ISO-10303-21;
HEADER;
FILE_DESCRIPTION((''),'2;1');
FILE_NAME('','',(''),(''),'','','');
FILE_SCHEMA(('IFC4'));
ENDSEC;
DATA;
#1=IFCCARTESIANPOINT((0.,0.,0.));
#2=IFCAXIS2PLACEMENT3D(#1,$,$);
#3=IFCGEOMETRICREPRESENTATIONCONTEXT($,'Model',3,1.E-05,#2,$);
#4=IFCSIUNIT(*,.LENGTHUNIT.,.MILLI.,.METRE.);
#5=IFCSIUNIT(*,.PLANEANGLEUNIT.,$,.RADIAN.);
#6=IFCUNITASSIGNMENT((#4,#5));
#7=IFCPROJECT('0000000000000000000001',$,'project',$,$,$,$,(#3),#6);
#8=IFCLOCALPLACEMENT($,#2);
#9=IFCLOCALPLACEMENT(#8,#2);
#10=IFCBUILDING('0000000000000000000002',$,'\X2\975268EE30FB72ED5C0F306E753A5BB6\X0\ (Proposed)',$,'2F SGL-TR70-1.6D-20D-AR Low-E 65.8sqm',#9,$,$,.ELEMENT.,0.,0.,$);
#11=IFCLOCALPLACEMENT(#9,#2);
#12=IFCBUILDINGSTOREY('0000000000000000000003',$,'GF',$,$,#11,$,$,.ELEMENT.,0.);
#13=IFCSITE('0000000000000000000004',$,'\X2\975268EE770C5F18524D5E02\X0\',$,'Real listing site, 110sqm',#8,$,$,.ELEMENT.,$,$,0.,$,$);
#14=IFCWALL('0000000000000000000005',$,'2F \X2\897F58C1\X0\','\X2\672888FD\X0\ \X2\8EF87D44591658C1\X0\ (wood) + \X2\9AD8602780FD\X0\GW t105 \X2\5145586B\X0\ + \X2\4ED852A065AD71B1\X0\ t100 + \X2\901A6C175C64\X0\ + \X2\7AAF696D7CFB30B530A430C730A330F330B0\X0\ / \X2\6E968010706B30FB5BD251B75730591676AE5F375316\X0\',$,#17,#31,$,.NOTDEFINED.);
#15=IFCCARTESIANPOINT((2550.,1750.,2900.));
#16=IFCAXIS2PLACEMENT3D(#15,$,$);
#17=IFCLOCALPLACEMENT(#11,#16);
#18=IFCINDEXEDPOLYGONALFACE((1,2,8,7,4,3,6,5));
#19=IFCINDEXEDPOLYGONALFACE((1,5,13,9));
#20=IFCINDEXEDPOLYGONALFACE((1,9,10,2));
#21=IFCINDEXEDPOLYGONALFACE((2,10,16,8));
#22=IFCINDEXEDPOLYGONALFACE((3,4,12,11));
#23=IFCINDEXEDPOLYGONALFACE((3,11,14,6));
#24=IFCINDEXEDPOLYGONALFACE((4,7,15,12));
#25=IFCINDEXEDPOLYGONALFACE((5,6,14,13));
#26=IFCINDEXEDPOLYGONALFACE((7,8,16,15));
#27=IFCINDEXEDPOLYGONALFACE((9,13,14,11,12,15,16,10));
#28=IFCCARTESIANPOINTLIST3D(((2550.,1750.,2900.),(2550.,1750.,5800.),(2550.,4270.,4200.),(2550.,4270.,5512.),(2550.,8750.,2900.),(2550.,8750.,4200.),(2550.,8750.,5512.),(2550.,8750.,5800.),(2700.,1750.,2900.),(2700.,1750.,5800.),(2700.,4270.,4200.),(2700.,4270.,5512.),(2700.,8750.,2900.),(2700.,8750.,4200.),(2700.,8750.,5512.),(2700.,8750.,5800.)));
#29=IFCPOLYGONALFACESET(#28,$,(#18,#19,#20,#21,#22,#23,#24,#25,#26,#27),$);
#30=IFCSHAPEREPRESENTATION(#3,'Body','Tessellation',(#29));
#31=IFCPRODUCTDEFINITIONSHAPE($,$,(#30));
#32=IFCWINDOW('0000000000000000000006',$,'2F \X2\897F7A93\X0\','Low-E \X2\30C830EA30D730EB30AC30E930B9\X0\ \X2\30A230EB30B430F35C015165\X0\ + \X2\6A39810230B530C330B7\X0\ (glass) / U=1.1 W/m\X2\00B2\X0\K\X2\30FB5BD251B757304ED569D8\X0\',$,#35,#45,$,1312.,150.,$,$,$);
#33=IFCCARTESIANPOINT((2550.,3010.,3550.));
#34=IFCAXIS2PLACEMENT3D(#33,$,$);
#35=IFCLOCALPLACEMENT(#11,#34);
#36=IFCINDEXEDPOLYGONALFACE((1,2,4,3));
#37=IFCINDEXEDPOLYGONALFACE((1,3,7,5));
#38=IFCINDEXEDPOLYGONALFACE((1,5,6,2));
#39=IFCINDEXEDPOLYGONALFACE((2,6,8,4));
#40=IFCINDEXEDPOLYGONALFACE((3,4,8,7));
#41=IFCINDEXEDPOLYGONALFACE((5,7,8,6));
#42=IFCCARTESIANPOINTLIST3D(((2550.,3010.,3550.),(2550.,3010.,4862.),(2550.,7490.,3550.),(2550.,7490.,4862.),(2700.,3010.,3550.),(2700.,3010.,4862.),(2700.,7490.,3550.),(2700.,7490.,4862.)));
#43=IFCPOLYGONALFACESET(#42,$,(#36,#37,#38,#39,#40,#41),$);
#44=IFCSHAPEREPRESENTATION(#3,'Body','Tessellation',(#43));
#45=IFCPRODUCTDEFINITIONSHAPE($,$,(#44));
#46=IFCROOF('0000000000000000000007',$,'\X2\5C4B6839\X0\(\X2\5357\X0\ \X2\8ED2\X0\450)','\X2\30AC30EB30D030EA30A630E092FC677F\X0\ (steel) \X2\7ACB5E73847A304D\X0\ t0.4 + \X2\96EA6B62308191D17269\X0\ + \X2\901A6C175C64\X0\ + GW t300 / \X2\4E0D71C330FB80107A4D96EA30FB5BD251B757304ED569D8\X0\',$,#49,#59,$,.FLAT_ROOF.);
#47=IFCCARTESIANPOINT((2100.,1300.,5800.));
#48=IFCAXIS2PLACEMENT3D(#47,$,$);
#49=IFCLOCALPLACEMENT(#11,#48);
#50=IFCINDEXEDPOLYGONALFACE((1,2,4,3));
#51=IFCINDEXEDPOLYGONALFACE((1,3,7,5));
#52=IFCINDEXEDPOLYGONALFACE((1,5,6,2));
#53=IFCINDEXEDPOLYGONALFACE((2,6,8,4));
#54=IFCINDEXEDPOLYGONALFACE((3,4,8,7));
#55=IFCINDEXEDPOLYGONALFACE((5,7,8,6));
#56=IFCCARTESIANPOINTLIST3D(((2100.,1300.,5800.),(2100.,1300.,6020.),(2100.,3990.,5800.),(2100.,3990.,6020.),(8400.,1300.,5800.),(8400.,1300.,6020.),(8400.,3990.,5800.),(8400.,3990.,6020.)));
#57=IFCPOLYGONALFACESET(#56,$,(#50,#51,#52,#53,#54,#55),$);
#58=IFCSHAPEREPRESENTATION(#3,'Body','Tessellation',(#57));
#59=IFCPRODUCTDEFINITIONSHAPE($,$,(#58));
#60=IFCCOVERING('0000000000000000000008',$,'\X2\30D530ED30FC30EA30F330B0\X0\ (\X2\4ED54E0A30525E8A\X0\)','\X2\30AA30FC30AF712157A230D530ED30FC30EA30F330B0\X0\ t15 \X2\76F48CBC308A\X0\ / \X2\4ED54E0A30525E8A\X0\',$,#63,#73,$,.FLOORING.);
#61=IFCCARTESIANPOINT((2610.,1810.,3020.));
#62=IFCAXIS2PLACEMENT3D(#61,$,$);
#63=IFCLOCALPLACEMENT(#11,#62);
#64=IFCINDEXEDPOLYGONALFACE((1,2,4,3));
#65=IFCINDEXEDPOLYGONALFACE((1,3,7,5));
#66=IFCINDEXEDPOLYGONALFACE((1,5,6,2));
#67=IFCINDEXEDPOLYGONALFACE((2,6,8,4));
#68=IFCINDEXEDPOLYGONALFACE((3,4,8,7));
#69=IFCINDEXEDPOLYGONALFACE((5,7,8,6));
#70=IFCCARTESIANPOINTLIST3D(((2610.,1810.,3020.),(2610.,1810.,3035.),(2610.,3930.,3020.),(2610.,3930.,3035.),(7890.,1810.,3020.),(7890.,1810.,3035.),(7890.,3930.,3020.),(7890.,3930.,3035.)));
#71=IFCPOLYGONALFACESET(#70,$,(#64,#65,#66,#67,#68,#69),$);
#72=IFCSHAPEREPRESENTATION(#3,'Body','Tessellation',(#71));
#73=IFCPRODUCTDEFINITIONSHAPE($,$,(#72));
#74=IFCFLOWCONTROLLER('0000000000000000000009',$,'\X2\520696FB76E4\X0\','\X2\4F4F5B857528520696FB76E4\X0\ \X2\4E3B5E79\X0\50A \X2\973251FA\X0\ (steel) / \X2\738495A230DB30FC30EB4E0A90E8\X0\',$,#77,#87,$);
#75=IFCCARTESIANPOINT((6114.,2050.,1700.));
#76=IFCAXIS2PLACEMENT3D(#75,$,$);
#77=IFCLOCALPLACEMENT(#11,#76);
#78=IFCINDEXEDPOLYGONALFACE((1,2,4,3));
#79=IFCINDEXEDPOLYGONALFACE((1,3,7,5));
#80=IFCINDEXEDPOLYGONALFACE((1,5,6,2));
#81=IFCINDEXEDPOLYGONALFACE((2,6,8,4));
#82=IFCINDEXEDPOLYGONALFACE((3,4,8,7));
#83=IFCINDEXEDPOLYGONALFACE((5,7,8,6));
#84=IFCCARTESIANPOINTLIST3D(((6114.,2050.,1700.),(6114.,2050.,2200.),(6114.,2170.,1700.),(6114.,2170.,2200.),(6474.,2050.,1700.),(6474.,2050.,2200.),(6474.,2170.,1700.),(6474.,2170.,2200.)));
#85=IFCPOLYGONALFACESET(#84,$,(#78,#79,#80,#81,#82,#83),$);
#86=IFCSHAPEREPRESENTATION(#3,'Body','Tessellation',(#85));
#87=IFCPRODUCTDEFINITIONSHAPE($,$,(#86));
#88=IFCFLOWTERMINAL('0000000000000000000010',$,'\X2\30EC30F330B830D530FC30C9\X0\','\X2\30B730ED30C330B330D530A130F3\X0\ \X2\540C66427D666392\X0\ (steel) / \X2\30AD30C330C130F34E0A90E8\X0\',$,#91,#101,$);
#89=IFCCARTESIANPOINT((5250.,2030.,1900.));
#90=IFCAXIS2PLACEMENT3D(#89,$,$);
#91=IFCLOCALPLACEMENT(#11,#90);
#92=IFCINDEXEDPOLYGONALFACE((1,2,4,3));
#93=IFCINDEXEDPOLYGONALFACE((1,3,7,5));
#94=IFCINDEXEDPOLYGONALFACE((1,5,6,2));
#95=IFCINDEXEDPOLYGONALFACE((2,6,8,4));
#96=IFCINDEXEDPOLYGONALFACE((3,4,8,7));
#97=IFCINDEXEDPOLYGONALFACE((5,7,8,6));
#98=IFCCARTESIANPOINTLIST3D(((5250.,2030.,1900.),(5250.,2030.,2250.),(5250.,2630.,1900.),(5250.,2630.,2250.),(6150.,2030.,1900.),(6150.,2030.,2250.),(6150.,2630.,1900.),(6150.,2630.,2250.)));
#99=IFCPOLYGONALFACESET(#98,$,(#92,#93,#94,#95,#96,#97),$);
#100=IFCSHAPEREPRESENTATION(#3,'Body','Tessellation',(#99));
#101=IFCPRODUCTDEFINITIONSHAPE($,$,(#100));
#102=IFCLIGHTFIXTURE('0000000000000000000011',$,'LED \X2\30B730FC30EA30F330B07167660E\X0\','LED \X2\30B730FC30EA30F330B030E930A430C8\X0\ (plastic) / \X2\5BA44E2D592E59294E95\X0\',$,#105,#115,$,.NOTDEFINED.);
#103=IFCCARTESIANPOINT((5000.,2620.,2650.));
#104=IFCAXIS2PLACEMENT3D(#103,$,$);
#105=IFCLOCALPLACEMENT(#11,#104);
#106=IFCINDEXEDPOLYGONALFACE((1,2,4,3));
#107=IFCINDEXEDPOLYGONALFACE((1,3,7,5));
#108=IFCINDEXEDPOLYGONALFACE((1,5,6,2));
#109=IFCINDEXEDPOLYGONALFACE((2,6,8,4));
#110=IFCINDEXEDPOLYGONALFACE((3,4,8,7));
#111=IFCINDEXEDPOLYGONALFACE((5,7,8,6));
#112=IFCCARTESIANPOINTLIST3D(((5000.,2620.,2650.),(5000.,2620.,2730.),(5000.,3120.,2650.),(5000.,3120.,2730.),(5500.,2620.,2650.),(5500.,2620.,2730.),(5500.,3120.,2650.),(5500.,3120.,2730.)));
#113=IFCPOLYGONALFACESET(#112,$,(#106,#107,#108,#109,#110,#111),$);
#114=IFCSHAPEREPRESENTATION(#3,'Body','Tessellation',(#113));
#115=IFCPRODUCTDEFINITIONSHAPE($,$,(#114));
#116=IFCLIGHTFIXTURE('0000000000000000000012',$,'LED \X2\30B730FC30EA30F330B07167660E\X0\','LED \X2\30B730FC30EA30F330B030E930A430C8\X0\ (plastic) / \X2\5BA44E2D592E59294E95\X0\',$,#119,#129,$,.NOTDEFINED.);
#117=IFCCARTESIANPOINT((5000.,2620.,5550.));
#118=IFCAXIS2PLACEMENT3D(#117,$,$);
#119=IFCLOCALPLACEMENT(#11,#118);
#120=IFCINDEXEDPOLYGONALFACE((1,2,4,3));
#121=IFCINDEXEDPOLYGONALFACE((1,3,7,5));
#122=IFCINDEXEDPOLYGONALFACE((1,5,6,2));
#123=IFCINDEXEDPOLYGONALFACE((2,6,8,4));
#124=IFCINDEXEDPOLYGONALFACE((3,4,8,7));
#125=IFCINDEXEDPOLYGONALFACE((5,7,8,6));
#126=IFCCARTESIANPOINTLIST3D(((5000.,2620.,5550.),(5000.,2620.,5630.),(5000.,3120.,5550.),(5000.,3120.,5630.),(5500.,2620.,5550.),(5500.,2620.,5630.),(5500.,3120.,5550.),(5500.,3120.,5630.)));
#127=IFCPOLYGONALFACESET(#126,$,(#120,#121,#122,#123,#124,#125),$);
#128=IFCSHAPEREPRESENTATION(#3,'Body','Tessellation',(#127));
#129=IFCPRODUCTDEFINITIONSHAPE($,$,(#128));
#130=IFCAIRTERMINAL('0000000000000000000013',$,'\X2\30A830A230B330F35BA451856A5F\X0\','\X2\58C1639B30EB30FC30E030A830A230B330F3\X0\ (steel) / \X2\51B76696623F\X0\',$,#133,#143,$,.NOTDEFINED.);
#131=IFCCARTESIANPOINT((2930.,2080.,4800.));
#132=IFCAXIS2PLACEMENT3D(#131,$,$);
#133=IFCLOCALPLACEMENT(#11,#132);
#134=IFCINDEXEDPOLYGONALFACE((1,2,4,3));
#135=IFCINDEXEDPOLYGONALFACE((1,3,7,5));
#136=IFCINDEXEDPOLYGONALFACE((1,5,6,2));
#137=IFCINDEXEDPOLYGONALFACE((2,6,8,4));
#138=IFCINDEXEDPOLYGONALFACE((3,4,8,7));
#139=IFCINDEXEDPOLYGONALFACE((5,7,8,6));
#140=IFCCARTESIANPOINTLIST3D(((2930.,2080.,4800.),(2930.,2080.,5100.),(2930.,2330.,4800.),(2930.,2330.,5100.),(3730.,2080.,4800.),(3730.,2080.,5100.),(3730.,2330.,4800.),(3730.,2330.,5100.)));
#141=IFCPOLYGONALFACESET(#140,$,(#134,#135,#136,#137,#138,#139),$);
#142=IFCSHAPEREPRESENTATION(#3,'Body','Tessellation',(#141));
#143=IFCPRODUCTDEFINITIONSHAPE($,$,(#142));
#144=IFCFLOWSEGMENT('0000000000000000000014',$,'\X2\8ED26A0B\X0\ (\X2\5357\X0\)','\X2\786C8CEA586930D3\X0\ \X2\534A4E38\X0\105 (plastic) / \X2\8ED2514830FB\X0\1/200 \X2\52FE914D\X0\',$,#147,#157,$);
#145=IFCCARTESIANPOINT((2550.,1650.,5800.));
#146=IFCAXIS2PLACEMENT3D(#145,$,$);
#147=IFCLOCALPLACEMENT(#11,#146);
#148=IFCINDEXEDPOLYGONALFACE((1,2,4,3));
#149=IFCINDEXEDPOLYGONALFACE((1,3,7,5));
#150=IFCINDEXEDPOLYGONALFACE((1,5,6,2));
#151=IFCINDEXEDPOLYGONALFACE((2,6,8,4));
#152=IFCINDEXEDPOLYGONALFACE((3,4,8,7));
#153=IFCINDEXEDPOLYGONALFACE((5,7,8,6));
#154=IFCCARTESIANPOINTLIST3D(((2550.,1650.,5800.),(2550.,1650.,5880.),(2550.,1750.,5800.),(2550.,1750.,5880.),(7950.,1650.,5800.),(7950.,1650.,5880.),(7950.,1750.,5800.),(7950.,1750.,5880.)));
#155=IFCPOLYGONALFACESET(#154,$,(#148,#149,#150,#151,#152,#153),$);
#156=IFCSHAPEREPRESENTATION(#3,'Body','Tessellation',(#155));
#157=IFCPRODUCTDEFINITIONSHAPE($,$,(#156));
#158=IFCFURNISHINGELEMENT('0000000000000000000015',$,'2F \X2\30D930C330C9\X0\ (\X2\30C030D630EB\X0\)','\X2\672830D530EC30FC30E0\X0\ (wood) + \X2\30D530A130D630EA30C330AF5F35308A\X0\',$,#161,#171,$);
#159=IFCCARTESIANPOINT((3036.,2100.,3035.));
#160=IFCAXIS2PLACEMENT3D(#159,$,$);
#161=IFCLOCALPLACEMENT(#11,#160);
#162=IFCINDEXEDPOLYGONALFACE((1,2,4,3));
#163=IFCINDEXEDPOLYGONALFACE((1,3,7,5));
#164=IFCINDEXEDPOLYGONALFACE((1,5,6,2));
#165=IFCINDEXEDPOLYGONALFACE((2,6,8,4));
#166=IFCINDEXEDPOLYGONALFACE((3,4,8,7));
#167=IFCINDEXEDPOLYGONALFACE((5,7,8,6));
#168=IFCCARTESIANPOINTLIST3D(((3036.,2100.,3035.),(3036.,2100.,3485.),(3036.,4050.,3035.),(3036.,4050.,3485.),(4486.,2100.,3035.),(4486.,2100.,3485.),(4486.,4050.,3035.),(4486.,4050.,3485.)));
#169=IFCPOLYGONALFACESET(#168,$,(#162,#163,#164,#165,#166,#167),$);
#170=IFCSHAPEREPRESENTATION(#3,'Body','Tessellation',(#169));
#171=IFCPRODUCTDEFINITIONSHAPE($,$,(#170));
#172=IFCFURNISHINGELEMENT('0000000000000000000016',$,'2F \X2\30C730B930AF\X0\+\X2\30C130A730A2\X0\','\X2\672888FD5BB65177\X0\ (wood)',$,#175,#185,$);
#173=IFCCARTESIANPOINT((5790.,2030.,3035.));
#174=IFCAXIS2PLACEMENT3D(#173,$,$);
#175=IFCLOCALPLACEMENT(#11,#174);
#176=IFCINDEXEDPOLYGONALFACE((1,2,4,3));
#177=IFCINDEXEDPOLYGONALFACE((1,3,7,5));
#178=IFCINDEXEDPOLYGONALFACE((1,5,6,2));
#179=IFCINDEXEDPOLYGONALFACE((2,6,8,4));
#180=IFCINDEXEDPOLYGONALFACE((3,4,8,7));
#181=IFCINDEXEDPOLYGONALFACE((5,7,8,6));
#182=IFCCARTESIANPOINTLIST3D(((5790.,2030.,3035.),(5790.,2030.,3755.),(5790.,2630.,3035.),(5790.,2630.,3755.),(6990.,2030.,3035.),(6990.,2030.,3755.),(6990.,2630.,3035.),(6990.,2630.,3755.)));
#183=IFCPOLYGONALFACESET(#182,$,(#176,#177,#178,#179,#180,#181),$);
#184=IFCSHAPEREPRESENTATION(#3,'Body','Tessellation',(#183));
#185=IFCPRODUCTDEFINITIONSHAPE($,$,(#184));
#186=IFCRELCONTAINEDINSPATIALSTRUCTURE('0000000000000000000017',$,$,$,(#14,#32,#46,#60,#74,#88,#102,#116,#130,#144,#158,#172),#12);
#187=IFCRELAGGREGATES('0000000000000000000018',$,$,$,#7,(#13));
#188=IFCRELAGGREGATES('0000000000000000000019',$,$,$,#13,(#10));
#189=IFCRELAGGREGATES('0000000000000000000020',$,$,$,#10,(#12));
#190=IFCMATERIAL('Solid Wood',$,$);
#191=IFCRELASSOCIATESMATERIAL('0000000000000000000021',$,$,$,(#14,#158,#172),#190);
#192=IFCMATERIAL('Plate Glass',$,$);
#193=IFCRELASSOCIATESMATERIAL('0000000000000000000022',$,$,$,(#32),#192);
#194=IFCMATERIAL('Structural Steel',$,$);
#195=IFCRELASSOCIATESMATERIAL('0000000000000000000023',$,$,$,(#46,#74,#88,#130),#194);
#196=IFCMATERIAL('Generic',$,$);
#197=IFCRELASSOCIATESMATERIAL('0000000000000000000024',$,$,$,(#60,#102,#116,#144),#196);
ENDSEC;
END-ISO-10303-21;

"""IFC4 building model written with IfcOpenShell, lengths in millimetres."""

from ifc_helpers import new_model, si_unit, frame, frame_2d, origin, place, context, project, spatial, rectangle, extrude, material, element, fill, save


model = new_model("IFC4")

# Units and contexts
model_context = context("Model", 3, precision=1e-05, world=origin())
ifc_project = project(units=[si_unit("LENGTHUNIT", "METRE", prefix="MILLI"), si_unit("PLANEANGLEUNIT", "RADIAN")], contexts=[model_context])

# Site, building, storey
site_placement = place(None, origin())
site = spatial("IfcSite", under=ifc_project, at=site_placement, Name="青森県弘前市", ObjectType="Real listing site, 110sqm", CompositionType="ELEMENT", RefElevation=0.0)
building_placement = place(site_placement, origin())
building = spatial("IfcBuilding", under=site, at=building_placement, Name="青森・狭小の町家 (Proposed)", ObjectType="2F SGL-TR70-1.6D-20D-AR Low-E 65.8sqm", CompositionType="ELEMENT", ElevationOfRefHeight=0.0, ElevationOfTerrain=0.0)
storey_placement = place(building_placement, origin())
storey = spatial("IfcBuildingStorey", under=building, at=storey_placement, Name="GF", CompositionType="ELEMENT", Elevation=0.0)

# Shared definitions
ifc_material_1 = material(Name="Solid Wood")

# Wall, opening, window
ifc_material_2 = material(Name="Plate Glass")
wall_1_placement = place(storey_placement, frame((2550.0, 1750.0, 2900.0)))
wall_1 = element("IfcWall", 1, at=wall_1_placement, inside=storey, material=ifc_material_1, Name="2F 西壁", Description="木製 軸組外壁 (wood) + 高性能GW t105 充填 + 付加断熱 t100 + 通気層 + 窯業系サイディング / 準耐火・寒冷地外皮強化", PredefinedType="NOTDEFINED", context=model_context, shape_type="SweptSolid", body=[
    extrude(rectangle(XDim=150.0, YDim=7000.0, at=frame_2d((75.0, 3500.0))), frame((2550.0, 1750.0, 2900.0)), (0.0, 0.0, 1.0), 2900.0),
])
opening_1_placement = place(storey_placement, frame((2550.0, 3010.0, 3550.0)))
opening_1 = element("IfcOpeningElement", 2, at=opening_1_placement, cuts=wall_1, PredefinedType="NOTDEFINED", context=model_context, shape_type="SweptSolid", body=[
    extrude(rectangle(XDim=150.0, YDim=4480.0, at=frame_2d((75.0, 2240.0))), frame((2550.0, 3010.0, 3550.0)), (0.0, 0.0, 1.0), 1312.0),
])
window_1_placement = place(storey_placement, frame((2550.0, 3010.0, 3550.0)))
window_1 = element("IfcWindow", 3, at=window_1_placement, inside=storey, material=ifc_material_2, Name="2F 西窓", Description="Low-E トリプルガラス アルゴン封入 + 樹脂サッシ (glass) / U=1.1 W/m²K・寒冷地仕様", OverallHeight=1312.0, OverallWidth=150.0, context=model_context, shape_type="SweptSolid", body=[
    extrude(rectangle(XDim=150.0, YDim=4480.0, at=frame_2d((75.0, 2240.0))), frame((2550.0, 3010.0, 3550.0)), (0.0, 0.0, 1.0), 1312.0),
])
fill(opening_1, window_1)

# Roof
ifc_material_3 = material(Name="Structural Steel")
for number, where, name in (
    (4, (2100.0, 1300.0, 5800.0), "屋根(南 軒450)"),
):
    element("IfcRoof", number, at=place(storey_placement, frame(where)), inside=storey, material=ifc_material_3, Name=name, Description="ガルバリウム鋼板 (steel) 立平葺き t0.4 + 雪止め金物 + 通気層 + GW t300 / 不燃・耐積雪・寒冷地仕様", PredefinedType="FLAT_ROOF", context=model_context, shape_type="SweptSolid", body=[
        extrude(rectangle(XDim=6300.0, YDim=2690.0, at=frame_2d((3150.0, 1345.0))), frame((2100.0, 1300.0, 5800.0)), (0.0, 0.0, 1.0), 220.0),
    ])

# Covering
ifc_material_4 = material(Name="Generic")
covering_placement = place(storey_placement, frame((2610.0, 1810.0, 3020.0)))
element("IfcCovering", 5, at=covering_placement, inside=storey, material=ifc_material_4, Name="フローリング (仕上げ床)", Description="オーク無垢フローリング t15 直貼り / 仕上げ床", PredefinedType="FLOORING", context=model_context, shape_type="SweptSolid", body=[
    extrude(rectangle(XDim=5280.0, YDim=2120.0, at=frame_2d((2640.0, 1060.0))), frame((2610.0, 1810.0, 3020.0)), (0.0, 0.0, 1.0), 15.0),
])

# Flow controller
flow_controller_placement = place(storey_placement, frame((6114.0, 2050.0, 1700.0)))
element("IfcFlowController", 6, at=flow_controller_placement, inside=storey, material=ifc_material_3, Name="分電盤", Description="住宅用分電盤 主幹50A 露出 (steel) / 玄関ホール上部", context=model_context, shape_type="SweptSolid", body=[
    extrude(rectangle(XDim=360.0, YDim=120.0, at=frame_2d((180.0, 60.0))), frame((6114.0, 2050.0, 1700.0)), (0.0, 0.0, 1.0), 500.0),
])

# Flow terminal
flow_terminal_placement = place(storey_placement, frame((5250.0, 2030.0, 1900.0)))
element("IfcFlowTerminal", 7, at=flow_terminal_placement, inside=storey, material=ifc_material_3, Name="レンジフード", Description="シロッコファン 同時給排 (steel) / キッチン上部", context=model_context, shape_type="SweptSolid", body=[
    extrude(rectangle(XDim=900.0, YDim=600.0, at=frame_2d((450.0, 300.0))), frame((5250.0, 2030.0, 1900.0)), (0.0, 0.0, 1.0), 350.0),
])

# Light fixtures
light_fixture_1_placement = place(storey_placement, frame((5000.0, 2620.0, 2650.0)))
element("IfcLightFixture", 8, at=light_fixture_1_placement, inside=storey, material=ifc_material_4, Name="LED シーリング照明", Description="LED シーリングライト (plastic) / 室中央天井", PredefinedType="NOTDEFINED", context=model_context, shape_type="SweptSolid", body=[
    extrude(rectangle(XDim=500.0, YDim=500.0, at=frame_2d((250.0, 250.0))), frame((5000.0, 2620.0, 2650.0)), (0.0, 0.0, 1.0), 80.0),
])
light_fixture_2_placement = place(storey_placement, frame((5000.0, 2620.0, 5550.0)))
element("IfcLightFixture", 9, at=light_fixture_2_placement, inside=storey, material=ifc_material_4, Name="LED シーリング照明", Description="LED シーリングライト (plastic) / 室中央天井", PredefinedType="NOTDEFINED", context=model_context, shape_type="SweptSolid", body=[
    extrude(rectangle(XDim=500.0, YDim=500.0, at=frame_2d((250.0, 250.0))), frame((5000.0, 2620.0, 5550.0)), (0.0, 0.0, 1.0), 80.0),
])

# Air terminal
air_terminal_placement = place(storey_placement, frame((2930.0, 2080.0, 4800.0)))
element("IfcAirTerminal", 10, at=air_terminal_placement, inside=storey, material=ifc_material_3, Name="エアコン室内機", Description="壁掛ルームエアコン (steel) / 冷暖房", PredefinedType="NOTDEFINED", context=model_context, shape_type="SweptSolid", body=[
    extrude(rectangle(XDim=800.0, YDim=250.0, at=frame_2d((400.0, 125.0))), frame((2930.0, 2080.0, 4800.0)), (0.0, 0.0, 1.0), 300.0),
])

# Flow segment
flow_segment_placement = place(storey_placement, frame((2550.0, 1650.0, 5800.0)))
element("IfcFlowSegment", 11, at=flow_segment_placement, inside=storey, material=ifc_material_4, Name="軒樋 (南)", Description="硬質塩ビ 半丸105 (plastic) / 軒先・1/200 勾配", context=model_context, shape_type="SweptSolid", body=[
    extrude(rectangle(XDim=5400.0, YDim=100.0, at=frame_2d((2700.0, 50.0))), frame((2550.0, 1650.0, 5800.0)), (0.0, 0.0, 1.0), 80.0),
])

# Furnishing elements
furnishing_1_placement = place(storey_placement, frame((3036.0, 2100.0, 3035.0)))
element("IfcFurnishingElement", 12, at=furnishing_1_placement, inside=storey, material=ifc_material_1, Name="2F ベッド (ダブル)", Description="木フレーム (wood) + ファブリック張り", context=model_context, shape_type="SweptSolid", body=[
    extrude(rectangle(XDim=1450.0, YDim=1950.0, at=frame_2d((725.0, 975.0))), frame((3036.0, 2100.0, 3035.0)), (0.0, 0.0, 1.0), 450.0),
])
furnishing_2_placement = place(storey_placement, frame((5790.0, 2030.0, 3035.0)))
element("IfcFurnishingElement", 13, at=furnishing_2_placement, inside=storey, material=ifc_material_1, Name="2F デスク+チェア", Description="木製家具 (wood)", context=model_context, shape_type="SweptSolid", body=[
    extrude(rectangle(XDim=1200.0, YDim=600.0, at=frame_2d((600.0, 300.0))), frame((5790.0, 2030.0, 3035.0)), (0.0, 0.0, 1.0), 720.0),
])

save(model, "model.ifc")
